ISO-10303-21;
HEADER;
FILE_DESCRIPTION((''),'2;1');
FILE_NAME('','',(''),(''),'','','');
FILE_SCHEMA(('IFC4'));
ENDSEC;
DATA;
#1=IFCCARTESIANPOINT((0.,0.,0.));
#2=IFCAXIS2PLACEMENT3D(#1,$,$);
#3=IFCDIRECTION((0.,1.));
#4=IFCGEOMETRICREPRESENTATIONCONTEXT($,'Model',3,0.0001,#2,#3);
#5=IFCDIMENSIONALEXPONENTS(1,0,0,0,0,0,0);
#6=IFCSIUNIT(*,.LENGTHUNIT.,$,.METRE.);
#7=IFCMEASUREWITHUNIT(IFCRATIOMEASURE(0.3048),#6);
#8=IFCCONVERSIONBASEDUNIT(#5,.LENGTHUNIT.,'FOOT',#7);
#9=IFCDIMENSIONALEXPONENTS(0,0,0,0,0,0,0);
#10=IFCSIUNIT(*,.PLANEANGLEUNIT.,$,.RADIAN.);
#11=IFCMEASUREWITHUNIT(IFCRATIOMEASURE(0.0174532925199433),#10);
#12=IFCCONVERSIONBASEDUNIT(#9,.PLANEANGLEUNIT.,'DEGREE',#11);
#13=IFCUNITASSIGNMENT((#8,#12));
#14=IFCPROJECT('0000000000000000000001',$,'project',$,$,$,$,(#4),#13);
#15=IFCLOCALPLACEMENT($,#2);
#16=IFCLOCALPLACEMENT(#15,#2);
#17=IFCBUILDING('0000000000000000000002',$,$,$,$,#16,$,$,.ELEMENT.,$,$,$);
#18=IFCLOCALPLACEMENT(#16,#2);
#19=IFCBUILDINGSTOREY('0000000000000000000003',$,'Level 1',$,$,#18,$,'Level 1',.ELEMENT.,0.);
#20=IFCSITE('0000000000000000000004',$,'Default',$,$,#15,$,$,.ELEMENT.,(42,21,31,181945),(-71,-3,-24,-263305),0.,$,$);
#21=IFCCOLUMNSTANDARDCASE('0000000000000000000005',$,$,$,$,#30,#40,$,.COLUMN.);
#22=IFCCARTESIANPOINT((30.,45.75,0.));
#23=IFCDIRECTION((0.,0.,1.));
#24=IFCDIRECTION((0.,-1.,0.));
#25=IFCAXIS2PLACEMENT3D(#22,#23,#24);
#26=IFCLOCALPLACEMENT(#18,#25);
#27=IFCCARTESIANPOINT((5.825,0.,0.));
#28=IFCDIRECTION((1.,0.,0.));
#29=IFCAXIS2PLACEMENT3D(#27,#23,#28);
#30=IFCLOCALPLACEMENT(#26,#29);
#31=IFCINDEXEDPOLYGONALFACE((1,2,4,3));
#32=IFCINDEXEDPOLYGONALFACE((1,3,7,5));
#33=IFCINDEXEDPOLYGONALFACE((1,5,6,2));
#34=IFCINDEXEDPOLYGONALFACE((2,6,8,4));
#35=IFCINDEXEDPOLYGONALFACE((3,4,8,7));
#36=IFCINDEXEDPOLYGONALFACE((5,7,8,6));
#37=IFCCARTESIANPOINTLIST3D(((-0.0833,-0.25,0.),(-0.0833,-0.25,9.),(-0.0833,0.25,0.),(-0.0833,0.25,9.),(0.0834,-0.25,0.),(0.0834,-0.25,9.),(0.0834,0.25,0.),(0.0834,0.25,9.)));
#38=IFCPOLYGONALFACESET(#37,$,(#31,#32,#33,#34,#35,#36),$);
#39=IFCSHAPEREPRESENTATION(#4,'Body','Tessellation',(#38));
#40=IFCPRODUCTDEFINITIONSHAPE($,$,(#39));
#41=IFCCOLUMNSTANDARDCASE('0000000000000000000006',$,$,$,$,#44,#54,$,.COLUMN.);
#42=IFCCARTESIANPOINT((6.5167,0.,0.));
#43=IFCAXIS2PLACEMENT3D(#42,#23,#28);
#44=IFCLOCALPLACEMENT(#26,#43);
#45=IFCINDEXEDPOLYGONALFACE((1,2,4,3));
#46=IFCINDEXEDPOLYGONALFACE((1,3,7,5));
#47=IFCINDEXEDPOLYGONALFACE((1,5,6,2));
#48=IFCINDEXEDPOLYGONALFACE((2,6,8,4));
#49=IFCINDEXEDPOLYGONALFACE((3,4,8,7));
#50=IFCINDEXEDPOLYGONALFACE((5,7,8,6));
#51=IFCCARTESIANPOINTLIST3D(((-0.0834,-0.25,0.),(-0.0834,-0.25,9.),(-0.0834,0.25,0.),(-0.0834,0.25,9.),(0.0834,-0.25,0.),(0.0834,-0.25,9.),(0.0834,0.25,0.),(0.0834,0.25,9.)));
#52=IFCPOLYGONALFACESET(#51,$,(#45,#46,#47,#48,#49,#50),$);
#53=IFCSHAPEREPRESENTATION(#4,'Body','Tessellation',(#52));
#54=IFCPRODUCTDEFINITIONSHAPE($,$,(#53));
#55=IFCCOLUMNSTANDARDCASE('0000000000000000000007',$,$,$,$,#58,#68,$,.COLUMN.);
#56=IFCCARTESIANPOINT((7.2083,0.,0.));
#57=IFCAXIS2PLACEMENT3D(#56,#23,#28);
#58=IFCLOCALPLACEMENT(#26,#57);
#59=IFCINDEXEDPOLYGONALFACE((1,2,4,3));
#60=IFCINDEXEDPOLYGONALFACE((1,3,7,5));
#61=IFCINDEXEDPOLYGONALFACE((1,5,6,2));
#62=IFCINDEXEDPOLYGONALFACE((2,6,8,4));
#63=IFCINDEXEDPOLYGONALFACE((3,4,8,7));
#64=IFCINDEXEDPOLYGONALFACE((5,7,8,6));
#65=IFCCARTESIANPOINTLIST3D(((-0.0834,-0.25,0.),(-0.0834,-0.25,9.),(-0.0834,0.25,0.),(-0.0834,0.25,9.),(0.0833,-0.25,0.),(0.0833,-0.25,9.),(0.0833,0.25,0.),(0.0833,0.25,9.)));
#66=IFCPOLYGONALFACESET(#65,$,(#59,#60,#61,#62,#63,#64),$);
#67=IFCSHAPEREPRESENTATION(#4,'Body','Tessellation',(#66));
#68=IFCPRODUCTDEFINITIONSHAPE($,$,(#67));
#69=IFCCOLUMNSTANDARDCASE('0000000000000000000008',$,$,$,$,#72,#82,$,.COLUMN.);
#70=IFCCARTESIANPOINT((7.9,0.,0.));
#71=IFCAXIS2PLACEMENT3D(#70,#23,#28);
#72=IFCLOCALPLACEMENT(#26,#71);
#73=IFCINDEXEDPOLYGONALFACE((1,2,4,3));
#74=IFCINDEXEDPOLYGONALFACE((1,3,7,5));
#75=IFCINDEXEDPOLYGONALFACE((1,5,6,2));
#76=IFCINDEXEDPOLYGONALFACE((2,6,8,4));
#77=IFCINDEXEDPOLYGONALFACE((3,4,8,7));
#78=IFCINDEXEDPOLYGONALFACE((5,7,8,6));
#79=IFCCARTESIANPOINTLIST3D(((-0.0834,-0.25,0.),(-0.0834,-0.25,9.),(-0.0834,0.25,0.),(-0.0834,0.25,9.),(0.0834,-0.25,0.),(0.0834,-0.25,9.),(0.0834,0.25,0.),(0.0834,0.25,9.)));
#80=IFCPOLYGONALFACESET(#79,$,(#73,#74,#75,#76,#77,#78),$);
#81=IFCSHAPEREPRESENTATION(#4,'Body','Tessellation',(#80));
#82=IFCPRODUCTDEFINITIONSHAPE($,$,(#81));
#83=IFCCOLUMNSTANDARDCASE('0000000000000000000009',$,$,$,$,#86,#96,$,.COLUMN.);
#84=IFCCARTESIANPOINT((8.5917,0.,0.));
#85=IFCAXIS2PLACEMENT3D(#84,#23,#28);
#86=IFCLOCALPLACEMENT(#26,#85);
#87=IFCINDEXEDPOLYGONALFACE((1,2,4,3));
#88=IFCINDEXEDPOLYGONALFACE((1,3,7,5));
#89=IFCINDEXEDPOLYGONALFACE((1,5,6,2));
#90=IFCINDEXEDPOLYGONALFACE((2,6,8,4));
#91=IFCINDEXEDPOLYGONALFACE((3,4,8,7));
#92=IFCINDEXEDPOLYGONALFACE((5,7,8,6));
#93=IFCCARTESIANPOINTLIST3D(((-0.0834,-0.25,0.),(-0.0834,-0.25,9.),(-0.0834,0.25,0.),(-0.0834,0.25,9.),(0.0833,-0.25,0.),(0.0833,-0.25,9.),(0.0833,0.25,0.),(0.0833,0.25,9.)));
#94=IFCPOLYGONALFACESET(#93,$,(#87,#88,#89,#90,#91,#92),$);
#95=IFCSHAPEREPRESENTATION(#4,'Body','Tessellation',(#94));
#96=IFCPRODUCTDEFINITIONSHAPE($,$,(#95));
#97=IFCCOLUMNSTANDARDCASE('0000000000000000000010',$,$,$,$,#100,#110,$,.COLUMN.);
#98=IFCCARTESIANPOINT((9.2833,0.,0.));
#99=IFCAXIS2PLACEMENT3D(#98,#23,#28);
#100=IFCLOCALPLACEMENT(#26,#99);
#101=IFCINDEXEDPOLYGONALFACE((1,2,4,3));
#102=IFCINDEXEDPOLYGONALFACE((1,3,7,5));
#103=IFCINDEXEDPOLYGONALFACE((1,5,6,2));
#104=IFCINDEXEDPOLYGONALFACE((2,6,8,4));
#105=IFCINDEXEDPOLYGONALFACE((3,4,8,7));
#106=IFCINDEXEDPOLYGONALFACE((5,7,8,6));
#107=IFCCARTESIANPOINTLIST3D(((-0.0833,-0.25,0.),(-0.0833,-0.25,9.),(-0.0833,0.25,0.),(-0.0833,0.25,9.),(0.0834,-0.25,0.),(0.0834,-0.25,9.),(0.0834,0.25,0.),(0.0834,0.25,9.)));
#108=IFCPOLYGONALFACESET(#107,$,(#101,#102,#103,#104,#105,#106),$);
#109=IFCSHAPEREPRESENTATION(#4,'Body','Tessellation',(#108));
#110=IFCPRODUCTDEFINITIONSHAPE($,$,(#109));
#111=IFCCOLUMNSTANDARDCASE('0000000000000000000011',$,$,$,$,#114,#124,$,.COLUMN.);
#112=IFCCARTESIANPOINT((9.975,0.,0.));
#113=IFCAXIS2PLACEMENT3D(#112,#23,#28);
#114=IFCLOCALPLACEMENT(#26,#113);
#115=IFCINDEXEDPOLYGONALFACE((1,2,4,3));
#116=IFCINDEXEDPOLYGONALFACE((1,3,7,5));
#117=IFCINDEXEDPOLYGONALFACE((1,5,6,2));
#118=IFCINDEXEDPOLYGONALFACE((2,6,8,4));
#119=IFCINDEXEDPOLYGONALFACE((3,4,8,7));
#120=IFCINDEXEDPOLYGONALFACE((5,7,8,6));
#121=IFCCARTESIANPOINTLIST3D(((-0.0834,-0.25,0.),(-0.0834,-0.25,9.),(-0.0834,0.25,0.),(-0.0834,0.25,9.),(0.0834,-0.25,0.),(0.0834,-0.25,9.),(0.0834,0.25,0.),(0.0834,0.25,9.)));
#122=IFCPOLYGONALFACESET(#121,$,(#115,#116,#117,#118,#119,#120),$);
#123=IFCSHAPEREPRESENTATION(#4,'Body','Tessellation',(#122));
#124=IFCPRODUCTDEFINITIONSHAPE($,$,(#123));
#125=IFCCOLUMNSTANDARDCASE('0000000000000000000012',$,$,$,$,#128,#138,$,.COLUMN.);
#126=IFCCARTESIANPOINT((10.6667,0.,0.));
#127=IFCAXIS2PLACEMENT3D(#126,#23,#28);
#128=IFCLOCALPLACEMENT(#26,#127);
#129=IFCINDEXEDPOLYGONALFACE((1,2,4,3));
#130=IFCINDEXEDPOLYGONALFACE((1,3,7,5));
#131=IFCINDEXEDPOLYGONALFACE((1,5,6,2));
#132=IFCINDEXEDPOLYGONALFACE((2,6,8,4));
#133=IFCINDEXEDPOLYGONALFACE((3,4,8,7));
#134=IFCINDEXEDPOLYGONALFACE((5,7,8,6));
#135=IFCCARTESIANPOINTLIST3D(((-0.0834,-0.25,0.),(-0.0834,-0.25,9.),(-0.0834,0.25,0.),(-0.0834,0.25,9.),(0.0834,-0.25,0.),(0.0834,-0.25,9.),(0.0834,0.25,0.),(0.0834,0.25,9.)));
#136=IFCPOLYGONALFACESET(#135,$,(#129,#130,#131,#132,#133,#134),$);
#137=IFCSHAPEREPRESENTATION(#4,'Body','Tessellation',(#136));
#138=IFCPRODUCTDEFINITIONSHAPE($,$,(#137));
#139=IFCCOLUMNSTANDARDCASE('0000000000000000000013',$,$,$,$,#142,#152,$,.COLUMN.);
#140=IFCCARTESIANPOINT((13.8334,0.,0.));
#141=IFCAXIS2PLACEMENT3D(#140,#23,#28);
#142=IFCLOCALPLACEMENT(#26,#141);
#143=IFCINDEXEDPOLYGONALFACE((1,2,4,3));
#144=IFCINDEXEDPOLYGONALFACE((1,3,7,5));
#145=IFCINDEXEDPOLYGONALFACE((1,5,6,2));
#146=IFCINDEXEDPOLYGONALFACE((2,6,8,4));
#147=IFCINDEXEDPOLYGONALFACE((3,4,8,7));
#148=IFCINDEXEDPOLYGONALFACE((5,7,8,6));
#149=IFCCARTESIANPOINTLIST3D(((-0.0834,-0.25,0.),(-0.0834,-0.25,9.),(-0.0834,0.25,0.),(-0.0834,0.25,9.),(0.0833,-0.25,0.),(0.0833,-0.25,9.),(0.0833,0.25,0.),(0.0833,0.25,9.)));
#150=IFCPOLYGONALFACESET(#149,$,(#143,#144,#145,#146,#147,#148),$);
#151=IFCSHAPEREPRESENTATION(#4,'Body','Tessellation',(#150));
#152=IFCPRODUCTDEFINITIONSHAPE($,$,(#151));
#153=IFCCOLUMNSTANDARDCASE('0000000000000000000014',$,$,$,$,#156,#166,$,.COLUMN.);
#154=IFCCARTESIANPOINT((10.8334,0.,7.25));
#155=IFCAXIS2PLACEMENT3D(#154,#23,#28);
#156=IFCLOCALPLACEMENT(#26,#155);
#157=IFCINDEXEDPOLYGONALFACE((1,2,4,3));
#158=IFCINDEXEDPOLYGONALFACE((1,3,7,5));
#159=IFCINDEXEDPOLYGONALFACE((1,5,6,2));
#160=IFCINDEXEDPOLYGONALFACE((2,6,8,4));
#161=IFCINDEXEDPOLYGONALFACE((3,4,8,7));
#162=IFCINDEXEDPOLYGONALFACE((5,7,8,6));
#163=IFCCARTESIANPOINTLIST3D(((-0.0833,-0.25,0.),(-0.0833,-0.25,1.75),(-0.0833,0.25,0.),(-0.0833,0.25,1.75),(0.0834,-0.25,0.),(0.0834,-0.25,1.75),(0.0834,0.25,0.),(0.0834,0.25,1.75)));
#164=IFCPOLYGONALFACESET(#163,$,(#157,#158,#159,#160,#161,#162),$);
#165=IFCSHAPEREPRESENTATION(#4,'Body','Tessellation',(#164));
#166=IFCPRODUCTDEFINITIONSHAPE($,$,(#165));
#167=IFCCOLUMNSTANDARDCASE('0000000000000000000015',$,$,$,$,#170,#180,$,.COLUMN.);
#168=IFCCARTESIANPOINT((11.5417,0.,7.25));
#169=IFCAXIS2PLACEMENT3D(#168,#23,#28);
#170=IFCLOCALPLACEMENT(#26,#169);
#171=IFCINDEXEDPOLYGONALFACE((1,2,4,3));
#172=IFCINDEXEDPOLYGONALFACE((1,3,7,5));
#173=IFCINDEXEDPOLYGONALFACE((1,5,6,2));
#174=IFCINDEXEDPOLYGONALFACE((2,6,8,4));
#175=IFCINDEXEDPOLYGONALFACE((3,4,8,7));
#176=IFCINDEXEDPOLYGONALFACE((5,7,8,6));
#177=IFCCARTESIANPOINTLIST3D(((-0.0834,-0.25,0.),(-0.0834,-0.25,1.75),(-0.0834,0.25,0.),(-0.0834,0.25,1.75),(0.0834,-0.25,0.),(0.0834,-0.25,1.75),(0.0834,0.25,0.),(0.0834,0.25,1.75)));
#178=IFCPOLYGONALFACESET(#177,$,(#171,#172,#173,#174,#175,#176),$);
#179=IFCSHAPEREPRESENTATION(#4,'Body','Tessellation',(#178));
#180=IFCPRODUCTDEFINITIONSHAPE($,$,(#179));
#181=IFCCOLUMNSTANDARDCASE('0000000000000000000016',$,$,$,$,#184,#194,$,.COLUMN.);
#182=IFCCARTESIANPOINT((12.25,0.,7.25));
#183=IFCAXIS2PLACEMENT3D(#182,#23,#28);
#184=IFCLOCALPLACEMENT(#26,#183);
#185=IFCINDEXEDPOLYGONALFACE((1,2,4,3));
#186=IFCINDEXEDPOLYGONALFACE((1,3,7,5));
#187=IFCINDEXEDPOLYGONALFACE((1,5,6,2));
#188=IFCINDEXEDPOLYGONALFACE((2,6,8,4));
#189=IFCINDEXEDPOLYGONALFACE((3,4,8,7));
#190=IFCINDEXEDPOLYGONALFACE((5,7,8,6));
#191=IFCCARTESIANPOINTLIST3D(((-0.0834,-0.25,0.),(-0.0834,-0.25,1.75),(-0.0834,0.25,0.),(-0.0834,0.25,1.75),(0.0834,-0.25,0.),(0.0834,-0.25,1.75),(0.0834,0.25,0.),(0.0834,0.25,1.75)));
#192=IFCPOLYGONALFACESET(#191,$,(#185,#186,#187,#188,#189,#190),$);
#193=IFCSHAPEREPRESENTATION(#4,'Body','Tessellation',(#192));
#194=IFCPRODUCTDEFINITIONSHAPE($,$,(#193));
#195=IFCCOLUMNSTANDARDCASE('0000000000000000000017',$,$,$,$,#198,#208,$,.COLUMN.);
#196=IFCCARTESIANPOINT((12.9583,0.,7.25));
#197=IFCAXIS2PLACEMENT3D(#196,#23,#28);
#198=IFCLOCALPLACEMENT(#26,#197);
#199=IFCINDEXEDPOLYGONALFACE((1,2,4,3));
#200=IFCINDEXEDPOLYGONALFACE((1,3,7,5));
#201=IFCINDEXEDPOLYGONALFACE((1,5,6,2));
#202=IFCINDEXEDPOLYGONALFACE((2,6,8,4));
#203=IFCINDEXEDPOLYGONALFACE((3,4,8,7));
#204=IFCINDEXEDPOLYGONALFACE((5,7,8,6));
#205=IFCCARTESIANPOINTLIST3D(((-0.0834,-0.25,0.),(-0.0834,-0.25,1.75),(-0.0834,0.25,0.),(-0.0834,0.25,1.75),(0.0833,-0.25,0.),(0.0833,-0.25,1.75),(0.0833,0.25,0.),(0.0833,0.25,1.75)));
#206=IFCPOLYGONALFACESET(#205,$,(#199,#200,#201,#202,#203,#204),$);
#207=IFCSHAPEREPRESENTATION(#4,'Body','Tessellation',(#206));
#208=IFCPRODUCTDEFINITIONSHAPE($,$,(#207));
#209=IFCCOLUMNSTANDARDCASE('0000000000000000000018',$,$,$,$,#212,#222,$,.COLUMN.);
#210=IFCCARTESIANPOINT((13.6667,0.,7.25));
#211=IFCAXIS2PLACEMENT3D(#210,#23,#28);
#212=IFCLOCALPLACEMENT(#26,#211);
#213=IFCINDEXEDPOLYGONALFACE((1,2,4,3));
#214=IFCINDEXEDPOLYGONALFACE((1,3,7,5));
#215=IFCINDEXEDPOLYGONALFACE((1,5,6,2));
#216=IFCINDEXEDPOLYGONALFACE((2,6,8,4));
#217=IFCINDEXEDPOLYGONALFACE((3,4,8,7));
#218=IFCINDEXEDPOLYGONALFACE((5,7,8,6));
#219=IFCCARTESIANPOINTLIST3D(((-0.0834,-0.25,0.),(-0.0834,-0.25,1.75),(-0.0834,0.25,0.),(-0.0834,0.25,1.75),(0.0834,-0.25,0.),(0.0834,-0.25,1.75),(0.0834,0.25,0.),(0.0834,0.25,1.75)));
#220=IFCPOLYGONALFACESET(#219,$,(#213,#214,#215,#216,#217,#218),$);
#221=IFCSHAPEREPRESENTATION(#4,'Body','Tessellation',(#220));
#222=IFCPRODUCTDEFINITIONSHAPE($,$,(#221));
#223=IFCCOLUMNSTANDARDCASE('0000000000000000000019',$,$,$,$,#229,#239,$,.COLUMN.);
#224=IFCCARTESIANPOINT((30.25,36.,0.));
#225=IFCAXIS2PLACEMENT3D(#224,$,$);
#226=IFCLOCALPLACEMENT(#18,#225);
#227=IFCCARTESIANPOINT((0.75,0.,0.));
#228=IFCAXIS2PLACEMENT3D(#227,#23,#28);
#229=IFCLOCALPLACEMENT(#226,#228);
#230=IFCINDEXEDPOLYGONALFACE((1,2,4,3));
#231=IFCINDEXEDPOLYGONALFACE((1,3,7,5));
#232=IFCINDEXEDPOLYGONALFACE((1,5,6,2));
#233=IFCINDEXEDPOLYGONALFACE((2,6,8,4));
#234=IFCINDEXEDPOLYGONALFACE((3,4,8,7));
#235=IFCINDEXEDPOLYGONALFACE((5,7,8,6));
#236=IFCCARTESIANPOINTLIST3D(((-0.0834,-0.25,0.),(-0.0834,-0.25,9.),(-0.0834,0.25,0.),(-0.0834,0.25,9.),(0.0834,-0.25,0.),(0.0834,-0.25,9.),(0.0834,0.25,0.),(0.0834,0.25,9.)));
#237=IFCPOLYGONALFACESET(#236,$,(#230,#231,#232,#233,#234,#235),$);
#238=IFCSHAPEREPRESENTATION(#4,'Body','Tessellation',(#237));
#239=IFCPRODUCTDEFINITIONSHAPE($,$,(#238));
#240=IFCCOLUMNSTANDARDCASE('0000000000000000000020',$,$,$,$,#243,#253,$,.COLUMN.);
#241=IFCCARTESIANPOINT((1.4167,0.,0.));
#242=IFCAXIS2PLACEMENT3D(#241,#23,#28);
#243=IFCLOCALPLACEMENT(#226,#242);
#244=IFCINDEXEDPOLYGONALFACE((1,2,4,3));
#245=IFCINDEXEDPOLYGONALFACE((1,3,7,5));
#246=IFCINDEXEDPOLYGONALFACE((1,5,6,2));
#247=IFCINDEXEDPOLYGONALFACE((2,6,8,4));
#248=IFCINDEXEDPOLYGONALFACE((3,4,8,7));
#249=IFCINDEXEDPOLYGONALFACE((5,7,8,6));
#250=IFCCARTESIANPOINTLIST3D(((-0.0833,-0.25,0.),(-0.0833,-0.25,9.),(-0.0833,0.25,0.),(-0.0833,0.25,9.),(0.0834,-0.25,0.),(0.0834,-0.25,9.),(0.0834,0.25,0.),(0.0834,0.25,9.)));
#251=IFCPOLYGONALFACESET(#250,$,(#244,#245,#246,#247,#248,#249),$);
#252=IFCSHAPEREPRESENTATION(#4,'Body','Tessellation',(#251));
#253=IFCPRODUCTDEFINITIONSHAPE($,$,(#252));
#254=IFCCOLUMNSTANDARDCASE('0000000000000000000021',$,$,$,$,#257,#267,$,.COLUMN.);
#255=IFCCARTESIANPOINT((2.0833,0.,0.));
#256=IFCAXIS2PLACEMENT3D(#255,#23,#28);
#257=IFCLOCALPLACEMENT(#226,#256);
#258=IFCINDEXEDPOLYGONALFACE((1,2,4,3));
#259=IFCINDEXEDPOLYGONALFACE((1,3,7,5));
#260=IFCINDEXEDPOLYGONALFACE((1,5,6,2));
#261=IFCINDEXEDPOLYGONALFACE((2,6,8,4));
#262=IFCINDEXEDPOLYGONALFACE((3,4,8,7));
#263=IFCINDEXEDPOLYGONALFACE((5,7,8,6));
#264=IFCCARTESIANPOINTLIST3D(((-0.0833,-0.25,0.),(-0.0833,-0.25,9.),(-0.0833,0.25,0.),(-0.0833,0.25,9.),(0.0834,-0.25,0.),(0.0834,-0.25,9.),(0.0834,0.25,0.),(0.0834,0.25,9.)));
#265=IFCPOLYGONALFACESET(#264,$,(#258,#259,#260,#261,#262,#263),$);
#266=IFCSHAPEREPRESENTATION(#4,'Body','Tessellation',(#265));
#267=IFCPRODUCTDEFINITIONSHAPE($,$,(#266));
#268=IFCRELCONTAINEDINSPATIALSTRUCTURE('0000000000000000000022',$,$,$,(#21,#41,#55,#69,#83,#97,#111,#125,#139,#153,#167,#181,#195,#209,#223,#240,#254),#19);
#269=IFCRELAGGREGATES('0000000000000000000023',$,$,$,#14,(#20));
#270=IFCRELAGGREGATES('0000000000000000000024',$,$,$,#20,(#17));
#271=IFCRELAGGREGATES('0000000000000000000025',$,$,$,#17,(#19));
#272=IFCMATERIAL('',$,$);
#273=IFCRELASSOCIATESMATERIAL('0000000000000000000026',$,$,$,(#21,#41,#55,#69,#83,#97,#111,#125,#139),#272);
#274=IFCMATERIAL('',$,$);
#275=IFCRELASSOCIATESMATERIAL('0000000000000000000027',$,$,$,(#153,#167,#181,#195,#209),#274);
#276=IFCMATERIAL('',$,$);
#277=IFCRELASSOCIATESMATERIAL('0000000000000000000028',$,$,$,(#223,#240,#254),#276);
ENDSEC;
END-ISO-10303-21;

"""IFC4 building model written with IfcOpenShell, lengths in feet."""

from ifc_helpers import new_model, entity, si_unit, converted_unit, direction, frame, origin, place, context, project, spatial, rectangle, extrude, material, element, save


model = new_model("IFC4")

# Units and contexts
model_context = context("Model", 3, precision=0.0001, world=origin(), true_north=direction((0.0, 1.0)))
ifc_project = project(units=[converted_unit("LENGTHUNIT", "FOOT", entity("IfcRatioMeasure", 0.3048), si_unit("LENGTHUNIT", "METRE"), dimensions=[1, 0, 0, 0, 0, 0, 0]), converted_unit("PLANEANGLEUNIT", "DEGREE", entity("IfcRatioMeasure", 0.0174532925199433), si_unit("PLANEANGLEUNIT", "RADIAN"), dimensions=[0, 0, 0, 0, 0, 0, 0])], contexts=[model_context])

# Site, building, storey
site_placement = place(None, origin())
site = spatial("IfcSite", under=ifc_project, at=site_placement, Name="Default", CompositionType="ELEMENT", RefLatitude=(42, 21, 31, 181945), RefLongitude=(-71, -3, -24, -263305), RefElevation=0.0)
building_placement = place(site_placement, origin())
building = spatial("IfcBuilding", under=site, at=building_placement, CompositionType="ELEMENT")
storey_placement = place(building_placement, origin())
storey = spatial("IfcBuildingStorey", under=building, at=storey_placement, Name="Level 1", LongName="Level 1", CompositionType="ELEMENT", Elevation=0.0)

# Columns
ifc_material_1 = material(Name="")
placement = place(storey_placement, frame((30.0, 45.75, 0.0), z_axis=(0.0, 0.0, 1.0), x_axis=(0.0, -1.0, 0.0)))
for number, where, z_axis, x_axis in (
    (1, (5.825, 0.0, 0.0), (0.0, 0.0, 1.0), (1.0, 0.0, 0.0)),
    (2, (6.5167, 0.0, 0.0), (0.0, 0.0, 1.0), (1.0, 0.0, 0.0)),
    (3, (7.2083, 0.0, 0.0), (0.0, 0.0, 1.0), (1.0, 0.0, 0.0)),
    (4, (7.9, 0.0, 0.0), (0.0, 0.0, 1.0), (1.0, 0.0, 0.0)),
    (5, (8.5917, 0.0, 0.0), (0.0, 0.0, 1.0), (1.0, 0.0, 0.0)),
    (6, (9.2833, 0.0, 0.0), (0.0, 0.0, 1.0), (1.0, 0.0, 0.0)),
    (7, (9.975, 0.0, 0.0), (0.0, 0.0, 1.0), (1.0, 0.0, 0.0)),
    (8, (10.6667, 0.0, 0.0), (0.0, 0.0, 1.0), (1.0, 0.0, 0.0)),
    (9, (13.8334, 0.0, 0.0), (0.0, 0.0, 1.0), (1.0, 0.0, 0.0)),
):
    element("IfcColumnStandardCase", number, at=place(placement, frame(where, z_axis=z_axis, x_axis=x_axis)), inside=storey, material=ifc_material_1, PredefinedType="COLUMN", context=model_context, shape_type="SweptSolid", body=[
        extrude(rectangle(XDim=0.1667, YDim=0.5), origin(), (0.0, 0.0, 1.0), 9.0),
    ])
ifc_material_2 = material(Name="")
for number, where, z_axis, x_axis in (
    (10, (10.8334, 0.0, 7.25), (0.0, 0.0, 1.0), (1.0, 0.0, 0.0)),
    (11, (11.5417, 0.0, 7.25), (0.0, 0.0, 1.0), (1.0, 0.0, 0.0)),
    (12, (12.25, 0.0, 7.25), (0.0, 0.0, 1.0), (1.0, 0.0, 0.0)),
    (13, (12.9583, 0.0, 7.25), (0.0, 0.0, 1.0), (1.0, 0.0, 0.0)),
    (14, (13.6667, 0.0, 7.25), (0.0, 0.0, 1.0), (1.0, 0.0, 0.0)),
):
    element("IfcColumnStandardCase", number, at=place(placement, frame(where, z_axis=z_axis, x_axis=x_axis)), inside=storey, material=ifc_material_2, PredefinedType="COLUMN", context=model_context, shape_type="SweptSolid", body=[
        extrude(rectangle(XDim=0.1667, YDim=0.5), origin(), (0.0, 0.0, 1.0), 1.75),
    ])
ifc_material_3 = material(Name="")
wall_placement = place(storey_placement, frame((30.25, 36.0, 0.0)))
for number, where, z_axis, x_axis in (
    (15, (0.75, 0.0, 0.0), (0.0, 0.0, 1.0), (1.0, 0.0, 0.0)),
    (16, (1.4167, 0.0, 0.0), (0.0, 0.0, 1.0), (1.0, 0.0, 0.0)),
    (17, (2.0833, 0.0, 0.0), (0.0, 0.0, 1.0), (1.0, 0.0, 0.0)),
):
    element("IfcColumnStandardCase", number, at=place(wall_placement, frame(where, z_axis=z_axis, x_axis=x_axis)), inside=storey, material=ifc_material_3, PredefinedType="COLUMN", context=model_context, shape_type="SweptSolid", body=[
        extrude(rectangle(XDim=0.1667, YDim=0.5), origin(), (0.0, 0.0, 1.0), 9.0),
    ])

save(model, "model.ifc")
